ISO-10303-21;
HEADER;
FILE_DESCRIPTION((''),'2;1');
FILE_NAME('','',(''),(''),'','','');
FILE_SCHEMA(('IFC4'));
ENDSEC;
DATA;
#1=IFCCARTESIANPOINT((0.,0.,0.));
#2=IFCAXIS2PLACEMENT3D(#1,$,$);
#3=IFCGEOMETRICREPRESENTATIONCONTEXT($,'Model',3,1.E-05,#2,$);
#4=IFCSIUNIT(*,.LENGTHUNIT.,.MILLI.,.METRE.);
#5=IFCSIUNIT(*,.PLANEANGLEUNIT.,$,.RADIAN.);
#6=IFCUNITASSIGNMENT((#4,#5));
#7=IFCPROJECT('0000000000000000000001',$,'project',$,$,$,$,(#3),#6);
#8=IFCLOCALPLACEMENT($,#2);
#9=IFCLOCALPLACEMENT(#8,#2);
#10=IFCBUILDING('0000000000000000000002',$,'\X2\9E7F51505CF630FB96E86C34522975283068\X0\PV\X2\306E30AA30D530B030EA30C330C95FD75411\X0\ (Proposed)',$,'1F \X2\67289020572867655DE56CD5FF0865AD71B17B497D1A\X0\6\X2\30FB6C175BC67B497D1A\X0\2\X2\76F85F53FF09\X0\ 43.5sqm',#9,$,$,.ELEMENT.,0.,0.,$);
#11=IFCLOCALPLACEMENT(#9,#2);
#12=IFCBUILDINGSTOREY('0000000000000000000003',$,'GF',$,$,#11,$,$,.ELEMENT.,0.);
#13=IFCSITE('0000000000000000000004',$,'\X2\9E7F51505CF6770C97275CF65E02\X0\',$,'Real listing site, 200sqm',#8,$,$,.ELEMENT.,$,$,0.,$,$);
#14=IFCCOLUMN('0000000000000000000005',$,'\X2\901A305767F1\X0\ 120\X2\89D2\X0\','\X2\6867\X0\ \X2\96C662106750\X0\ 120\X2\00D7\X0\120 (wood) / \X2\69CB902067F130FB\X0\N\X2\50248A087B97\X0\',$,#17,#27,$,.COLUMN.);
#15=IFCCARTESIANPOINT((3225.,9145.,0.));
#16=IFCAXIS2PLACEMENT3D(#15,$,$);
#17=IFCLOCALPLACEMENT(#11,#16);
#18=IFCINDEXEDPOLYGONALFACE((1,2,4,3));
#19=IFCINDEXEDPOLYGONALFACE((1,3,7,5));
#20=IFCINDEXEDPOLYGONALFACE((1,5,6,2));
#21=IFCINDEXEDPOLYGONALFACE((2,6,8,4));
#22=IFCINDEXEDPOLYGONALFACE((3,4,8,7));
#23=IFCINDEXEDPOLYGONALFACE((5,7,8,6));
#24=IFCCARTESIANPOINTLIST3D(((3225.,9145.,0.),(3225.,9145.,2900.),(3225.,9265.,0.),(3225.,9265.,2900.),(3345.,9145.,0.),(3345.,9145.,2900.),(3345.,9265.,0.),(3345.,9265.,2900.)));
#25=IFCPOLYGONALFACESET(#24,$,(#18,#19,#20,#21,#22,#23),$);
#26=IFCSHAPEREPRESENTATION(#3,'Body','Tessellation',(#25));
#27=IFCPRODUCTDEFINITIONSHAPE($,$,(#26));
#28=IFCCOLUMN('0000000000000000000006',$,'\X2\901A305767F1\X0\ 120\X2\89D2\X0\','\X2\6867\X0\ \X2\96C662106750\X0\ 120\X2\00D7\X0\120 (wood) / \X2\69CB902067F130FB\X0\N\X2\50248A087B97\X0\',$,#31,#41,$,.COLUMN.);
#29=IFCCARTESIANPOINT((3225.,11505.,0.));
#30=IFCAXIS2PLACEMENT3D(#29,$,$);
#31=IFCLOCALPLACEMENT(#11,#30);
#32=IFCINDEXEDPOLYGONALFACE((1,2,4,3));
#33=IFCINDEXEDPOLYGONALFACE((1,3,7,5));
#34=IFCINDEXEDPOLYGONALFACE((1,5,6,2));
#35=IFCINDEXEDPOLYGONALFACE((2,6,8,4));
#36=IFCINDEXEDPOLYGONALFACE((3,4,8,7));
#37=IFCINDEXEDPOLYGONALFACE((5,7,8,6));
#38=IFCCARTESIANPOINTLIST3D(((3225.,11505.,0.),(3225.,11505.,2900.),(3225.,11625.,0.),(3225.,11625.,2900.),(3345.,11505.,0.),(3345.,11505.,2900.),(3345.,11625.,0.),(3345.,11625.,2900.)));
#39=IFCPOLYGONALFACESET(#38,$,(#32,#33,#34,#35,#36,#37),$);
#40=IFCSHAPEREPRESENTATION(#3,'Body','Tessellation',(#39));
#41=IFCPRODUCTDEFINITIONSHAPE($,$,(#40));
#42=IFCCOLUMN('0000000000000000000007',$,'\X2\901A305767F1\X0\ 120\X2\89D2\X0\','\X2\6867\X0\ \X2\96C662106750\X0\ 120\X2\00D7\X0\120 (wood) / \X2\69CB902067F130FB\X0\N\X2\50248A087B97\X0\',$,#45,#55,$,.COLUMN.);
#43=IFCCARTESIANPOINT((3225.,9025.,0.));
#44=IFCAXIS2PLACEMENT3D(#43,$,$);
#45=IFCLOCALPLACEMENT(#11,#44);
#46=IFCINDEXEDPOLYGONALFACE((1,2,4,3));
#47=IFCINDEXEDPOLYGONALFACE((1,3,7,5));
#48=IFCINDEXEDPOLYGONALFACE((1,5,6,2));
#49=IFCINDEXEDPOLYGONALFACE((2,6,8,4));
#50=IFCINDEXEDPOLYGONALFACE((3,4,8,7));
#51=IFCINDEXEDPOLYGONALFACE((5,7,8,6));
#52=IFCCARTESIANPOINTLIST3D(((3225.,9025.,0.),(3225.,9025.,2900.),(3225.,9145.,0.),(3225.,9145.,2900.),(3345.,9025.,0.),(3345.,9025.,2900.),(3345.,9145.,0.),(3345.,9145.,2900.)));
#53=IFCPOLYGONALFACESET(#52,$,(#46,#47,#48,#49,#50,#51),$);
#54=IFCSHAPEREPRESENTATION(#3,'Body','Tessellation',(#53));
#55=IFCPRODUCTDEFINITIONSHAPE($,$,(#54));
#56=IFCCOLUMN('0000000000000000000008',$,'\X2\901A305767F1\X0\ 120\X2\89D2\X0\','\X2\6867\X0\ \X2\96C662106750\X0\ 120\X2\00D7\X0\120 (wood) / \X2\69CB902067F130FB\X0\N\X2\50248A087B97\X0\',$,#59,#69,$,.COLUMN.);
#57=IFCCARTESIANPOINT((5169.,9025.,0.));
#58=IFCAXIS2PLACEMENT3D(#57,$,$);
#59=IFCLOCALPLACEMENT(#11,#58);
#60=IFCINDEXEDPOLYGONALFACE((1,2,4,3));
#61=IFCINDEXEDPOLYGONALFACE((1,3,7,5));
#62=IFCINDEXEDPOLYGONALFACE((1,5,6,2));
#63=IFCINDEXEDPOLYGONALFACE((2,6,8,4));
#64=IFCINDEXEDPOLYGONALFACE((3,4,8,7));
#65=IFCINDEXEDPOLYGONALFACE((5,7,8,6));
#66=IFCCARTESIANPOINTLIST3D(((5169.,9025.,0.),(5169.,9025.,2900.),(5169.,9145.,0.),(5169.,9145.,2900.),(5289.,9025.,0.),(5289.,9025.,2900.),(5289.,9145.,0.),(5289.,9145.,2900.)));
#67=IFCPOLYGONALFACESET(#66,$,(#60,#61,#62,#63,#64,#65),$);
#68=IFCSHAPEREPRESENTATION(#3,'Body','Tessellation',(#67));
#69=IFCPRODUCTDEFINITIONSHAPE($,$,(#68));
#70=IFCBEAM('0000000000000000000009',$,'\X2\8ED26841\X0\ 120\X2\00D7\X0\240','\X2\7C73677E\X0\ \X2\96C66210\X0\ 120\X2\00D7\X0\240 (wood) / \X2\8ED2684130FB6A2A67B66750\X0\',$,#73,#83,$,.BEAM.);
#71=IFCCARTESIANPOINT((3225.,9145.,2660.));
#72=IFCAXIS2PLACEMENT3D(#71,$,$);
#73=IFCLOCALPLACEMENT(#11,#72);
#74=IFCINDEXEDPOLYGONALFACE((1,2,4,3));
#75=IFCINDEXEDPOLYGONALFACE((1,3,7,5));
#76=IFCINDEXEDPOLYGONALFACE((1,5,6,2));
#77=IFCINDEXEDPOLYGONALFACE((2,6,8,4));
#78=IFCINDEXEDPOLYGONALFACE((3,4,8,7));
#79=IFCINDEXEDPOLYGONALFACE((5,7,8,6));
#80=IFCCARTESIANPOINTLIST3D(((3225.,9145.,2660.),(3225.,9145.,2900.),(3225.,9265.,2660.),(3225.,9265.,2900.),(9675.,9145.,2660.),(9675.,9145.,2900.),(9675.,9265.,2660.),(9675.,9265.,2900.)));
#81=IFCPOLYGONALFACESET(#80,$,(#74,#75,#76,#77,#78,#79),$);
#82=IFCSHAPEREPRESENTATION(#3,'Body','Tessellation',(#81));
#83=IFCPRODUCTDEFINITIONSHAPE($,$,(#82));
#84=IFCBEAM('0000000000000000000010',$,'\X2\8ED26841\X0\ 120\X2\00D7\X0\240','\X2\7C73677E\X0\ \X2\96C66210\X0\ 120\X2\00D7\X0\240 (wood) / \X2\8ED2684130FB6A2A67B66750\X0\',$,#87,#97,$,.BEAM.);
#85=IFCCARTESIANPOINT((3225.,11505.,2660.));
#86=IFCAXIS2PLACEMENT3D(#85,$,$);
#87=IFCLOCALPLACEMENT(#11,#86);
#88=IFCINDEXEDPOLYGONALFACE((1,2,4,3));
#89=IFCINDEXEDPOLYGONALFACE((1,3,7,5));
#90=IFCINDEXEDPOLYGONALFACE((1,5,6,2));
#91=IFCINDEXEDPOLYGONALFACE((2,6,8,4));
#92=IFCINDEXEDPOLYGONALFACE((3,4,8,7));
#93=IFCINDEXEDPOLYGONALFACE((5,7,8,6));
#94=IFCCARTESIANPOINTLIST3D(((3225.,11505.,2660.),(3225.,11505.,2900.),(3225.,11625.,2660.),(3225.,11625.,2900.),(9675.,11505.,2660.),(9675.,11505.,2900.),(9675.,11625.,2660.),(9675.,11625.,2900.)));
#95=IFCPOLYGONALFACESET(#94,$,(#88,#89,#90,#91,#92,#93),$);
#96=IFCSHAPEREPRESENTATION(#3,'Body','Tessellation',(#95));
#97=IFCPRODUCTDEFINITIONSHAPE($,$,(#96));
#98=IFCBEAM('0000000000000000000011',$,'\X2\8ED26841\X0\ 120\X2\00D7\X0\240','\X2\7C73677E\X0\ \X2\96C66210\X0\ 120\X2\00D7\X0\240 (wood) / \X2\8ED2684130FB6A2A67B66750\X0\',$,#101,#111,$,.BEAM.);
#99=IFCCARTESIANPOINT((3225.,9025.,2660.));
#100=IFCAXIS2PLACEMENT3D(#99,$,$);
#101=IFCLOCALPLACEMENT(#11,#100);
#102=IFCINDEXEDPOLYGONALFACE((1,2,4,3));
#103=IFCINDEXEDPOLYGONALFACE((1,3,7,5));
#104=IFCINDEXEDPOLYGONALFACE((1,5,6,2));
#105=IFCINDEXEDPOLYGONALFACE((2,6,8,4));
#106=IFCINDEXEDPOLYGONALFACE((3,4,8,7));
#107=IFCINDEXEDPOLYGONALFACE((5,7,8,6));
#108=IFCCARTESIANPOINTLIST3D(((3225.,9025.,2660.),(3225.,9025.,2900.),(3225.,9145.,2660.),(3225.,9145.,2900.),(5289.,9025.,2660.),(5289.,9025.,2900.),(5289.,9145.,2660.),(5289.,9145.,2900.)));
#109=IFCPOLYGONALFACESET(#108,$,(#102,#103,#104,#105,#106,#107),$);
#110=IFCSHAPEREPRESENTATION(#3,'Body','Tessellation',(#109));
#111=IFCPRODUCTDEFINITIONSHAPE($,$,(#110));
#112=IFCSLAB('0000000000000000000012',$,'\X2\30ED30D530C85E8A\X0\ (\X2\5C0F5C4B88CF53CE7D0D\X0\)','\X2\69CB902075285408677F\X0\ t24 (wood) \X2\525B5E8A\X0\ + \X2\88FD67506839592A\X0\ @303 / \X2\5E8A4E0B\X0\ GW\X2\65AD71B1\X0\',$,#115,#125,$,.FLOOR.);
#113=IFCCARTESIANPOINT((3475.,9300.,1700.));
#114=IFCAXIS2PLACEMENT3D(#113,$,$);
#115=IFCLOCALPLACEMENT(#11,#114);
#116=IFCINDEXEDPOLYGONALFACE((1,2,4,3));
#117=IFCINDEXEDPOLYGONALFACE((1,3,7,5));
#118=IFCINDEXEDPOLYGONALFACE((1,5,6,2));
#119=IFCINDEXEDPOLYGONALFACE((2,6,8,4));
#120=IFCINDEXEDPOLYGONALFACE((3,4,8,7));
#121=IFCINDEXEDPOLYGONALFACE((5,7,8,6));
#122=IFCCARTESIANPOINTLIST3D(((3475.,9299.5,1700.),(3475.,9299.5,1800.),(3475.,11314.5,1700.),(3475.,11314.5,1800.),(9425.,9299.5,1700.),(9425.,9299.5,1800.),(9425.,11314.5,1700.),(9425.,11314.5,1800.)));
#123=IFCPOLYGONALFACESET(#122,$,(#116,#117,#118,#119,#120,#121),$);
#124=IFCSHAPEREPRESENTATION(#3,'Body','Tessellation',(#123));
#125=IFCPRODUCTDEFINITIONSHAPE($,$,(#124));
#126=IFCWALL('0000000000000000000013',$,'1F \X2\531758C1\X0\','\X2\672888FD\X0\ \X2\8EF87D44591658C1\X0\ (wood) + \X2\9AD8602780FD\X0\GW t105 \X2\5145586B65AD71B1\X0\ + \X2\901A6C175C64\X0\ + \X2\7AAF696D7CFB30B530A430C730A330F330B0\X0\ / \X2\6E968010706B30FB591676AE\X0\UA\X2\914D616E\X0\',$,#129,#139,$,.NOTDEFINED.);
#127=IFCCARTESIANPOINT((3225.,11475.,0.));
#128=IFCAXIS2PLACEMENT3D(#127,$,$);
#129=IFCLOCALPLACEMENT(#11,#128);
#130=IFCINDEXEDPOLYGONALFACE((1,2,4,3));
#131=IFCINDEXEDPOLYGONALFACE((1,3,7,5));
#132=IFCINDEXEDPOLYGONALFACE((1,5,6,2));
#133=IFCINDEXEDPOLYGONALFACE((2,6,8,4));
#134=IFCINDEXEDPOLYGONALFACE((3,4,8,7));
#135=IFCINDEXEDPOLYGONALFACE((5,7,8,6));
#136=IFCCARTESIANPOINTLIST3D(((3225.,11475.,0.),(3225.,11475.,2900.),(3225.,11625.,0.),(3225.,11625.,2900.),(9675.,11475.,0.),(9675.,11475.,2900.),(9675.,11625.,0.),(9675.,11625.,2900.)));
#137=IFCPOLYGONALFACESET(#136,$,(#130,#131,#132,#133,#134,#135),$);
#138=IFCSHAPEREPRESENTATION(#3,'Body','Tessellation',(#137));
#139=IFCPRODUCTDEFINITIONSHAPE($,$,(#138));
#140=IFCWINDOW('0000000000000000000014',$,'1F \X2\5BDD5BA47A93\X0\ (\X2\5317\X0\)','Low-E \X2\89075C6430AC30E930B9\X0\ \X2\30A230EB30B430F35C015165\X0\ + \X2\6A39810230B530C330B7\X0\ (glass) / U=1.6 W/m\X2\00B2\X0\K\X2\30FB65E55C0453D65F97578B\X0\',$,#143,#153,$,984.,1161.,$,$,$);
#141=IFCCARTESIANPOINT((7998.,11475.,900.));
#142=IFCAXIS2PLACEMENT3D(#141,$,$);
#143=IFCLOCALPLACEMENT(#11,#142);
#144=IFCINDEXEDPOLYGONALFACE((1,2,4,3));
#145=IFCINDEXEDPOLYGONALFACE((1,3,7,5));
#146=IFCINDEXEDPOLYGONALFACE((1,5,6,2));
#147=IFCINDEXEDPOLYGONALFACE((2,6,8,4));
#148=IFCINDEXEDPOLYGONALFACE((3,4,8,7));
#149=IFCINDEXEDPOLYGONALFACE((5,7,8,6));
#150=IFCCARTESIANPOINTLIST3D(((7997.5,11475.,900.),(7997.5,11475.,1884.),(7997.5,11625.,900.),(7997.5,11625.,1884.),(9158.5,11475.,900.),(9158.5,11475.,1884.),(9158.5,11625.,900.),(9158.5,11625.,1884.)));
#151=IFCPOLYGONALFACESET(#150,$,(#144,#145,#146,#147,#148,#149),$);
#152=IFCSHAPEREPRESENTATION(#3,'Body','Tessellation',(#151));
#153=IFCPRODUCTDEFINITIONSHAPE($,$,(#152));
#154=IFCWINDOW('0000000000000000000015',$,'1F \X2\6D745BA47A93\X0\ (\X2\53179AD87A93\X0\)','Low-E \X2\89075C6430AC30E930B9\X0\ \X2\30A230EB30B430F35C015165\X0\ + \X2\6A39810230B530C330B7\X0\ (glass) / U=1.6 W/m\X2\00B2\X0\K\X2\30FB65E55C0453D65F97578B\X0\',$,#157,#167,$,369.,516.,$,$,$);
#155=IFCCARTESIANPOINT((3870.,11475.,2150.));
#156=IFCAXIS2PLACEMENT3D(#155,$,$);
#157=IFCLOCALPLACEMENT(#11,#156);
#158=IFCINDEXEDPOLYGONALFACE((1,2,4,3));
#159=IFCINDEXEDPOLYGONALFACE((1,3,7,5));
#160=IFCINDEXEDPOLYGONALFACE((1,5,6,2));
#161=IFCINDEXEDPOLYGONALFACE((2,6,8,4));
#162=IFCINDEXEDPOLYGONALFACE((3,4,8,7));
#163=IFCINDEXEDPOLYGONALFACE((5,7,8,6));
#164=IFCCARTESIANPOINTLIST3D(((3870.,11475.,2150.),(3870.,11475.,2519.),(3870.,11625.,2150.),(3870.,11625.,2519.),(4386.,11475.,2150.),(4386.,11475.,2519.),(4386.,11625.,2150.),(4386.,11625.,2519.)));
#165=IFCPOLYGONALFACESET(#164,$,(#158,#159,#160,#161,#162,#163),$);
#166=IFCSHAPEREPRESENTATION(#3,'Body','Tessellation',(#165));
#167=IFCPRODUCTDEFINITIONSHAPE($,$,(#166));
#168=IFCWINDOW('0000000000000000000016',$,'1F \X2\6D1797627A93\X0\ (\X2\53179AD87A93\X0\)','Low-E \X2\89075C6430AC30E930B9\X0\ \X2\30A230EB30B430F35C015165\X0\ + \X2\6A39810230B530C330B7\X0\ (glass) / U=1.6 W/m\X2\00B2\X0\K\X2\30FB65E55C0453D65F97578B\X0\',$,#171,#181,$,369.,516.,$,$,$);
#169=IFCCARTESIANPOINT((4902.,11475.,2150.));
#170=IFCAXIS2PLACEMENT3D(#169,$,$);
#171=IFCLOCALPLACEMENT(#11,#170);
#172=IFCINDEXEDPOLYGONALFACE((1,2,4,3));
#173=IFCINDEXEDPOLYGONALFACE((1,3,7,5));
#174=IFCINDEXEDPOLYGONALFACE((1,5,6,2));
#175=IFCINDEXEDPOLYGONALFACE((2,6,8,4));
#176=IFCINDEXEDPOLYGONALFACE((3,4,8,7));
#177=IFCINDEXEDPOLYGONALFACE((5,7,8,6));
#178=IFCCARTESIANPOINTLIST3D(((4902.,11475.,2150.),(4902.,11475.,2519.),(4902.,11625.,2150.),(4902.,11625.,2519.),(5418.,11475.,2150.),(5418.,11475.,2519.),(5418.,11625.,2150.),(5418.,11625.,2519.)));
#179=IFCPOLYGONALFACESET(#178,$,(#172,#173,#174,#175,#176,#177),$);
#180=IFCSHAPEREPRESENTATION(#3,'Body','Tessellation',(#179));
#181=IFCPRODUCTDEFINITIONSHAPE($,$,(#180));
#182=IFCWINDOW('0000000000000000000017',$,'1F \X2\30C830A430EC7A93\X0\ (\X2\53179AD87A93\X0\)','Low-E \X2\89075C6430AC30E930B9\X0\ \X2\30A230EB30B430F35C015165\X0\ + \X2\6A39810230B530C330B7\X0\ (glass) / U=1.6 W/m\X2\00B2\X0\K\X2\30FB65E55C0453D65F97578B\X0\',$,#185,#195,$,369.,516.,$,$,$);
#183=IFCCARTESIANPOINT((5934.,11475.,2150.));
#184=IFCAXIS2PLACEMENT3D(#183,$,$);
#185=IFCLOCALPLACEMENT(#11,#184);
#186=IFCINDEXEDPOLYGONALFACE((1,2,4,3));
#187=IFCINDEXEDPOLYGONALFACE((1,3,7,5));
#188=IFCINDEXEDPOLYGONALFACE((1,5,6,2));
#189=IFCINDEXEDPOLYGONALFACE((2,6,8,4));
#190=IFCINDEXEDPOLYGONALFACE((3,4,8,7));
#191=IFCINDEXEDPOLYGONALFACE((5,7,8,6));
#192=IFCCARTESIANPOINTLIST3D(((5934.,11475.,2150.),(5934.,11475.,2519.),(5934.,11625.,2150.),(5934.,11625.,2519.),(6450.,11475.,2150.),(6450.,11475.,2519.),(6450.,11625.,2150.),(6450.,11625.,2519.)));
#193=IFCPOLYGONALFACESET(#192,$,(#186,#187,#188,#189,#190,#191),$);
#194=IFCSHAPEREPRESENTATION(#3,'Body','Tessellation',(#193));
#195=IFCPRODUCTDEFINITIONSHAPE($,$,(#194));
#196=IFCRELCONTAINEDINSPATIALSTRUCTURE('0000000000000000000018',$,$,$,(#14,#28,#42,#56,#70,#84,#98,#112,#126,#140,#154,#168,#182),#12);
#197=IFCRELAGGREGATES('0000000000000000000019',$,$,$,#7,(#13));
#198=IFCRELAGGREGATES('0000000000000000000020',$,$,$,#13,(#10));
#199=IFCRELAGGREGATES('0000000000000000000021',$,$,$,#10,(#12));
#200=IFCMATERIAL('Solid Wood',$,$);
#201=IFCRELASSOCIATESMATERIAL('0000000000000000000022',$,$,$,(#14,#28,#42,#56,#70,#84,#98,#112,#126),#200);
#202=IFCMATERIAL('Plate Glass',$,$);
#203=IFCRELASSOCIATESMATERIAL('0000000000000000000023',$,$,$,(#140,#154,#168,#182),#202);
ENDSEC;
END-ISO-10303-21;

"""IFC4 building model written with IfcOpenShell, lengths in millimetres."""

from ifc_helpers import new_model, si_unit, frame, frame_2d, origin, place, context, project, spatial, rectangle, extrude, material, element, fill, save


model = new_model("IFC4")

# Units and contexts
model_context = context("Model", 3, precision=1e-05, world=origin())
ifc_project = project(units=[si_unit("LENGTHUNIT", "METRE", prefix="MILLI"), si_unit("PLANEANGLEUNIT", "RADIAN")], contexts=[model_context])

# Site, building, storey
site_placement = place(None, origin())
site = spatial("IfcSite", under=ifc_project, at=site_placement, Name="鹿児島県霧島市", ObjectType="Real listing site, 200sqm", CompositionType="ELEMENT", RefElevation=0.0)
building_placement = place(site_placement, origin())
building = spatial("IfcBuilding", under=site, at=building_placement, Name="鹿児島・雨水利用とPVのオフグリッド志向 (Proposed)", ObjectType="1F 木造在来工法（断熱等級6・気密等級2相当） 43.5sqm", CompositionType="ELEMENT", ElevationOfRefHeight=0.0, ElevationOfTerrain=0.0)
storey_placement = place(building_placement, origin())
storey = spatial("IfcBuildingStorey", under=building, at=storey_placement, Name="GF", CompositionType="ELEMENT", Elevation=0.0)

# Columns
ifc_material_1 = material(Name="Solid Wood")
column_1_placement = place(storey_placement, frame((3225.0, 9145.0, 0.0)))
element("IfcColumn", 1, at=column_1_placement, inside=storey, material=ifc_material_1, Name="通し柱 120角", Description="桧 集成材 120×120 (wood) / 構造柱・N値計算", PredefinedType="COLUMN", context=model_context, shape_type="SweptSolid", body=[
    extrude(rectangle(XDim=120.0, YDim=120.0, at=frame_2d((60.0, 60.0))), frame((3225.0, 9145.0, 0.0)), (0.0, 0.0, 1.0), 2900.0),
])
column_2_placement = place(storey_placement, frame((3225.0, 11505.0, 0.0)))
element("IfcColumn", 2, at=column_2_placement, inside=storey, material=ifc_material_1, Name="通し柱 120角", Description="桧 集成材 120×120 (wood) / 構造柱・N値計算", PredefinedType="COLUMN", context=model_context, shape_type="SweptSolid", body=[
    extrude(rectangle(XDim=120.0, YDim=120.0, at=frame_2d((60.0, 60.0))), frame((3225.0, 11505.0, 0.0)), (0.0, 0.0, 1.0), 2900.0),
])
column_3_placement = place(storey_placement, frame((3225.0, 9025.0, 0.0)))
element("IfcColumn", 3, at=column_3_placement, inside=storey, material=ifc_material_1, Name="通し柱 120角", Description="桧 集成材 120×120 (wood) / 構造柱・N値計算", PredefinedType="COLUMN", context=model_context, shape_type="SweptSolid", body=[
    extrude(rectangle(XDim=120.0, YDim=120.0, at=frame_2d((60.0, 60.0))), frame((3225.0, 9025.0, 0.0)), (0.0, 0.0, 1.0), 2900.0),
])
column_4_placement = place(storey_placement, frame((5169.0, 9025.0, 0.0)))
element("IfcColumn", 4, at=column_4_placement, inside=storey, material=ifc_material_1, Name="通し柱 120角", Description="桧 集成材 120×120 (wood) / 構造柱・N値計算", PredefinedType="COLUMN", context=model_context, shape_type="SweptSolid", body=[
    extrude(rectangle(XDim=120.0, YDim=120.0, at=frame_2d((60.0, 60.0))), frame((5169.0, 9025.0, 0.0)), (0.0, 0.0, 1.0), 2900.0),
])

# Beams
beam_1_placement = place(storey_placement, frame((3225.0, 9145.0, 2660.0)))
element("IfcBeam", 5, at=beam_1_placement, inside=storey, material=ifc_material_1, Name="軒桁 120×240", Description="米松 集成 120×240 (wood) / 軒桁・横架材", PredefinedType="BEAM", context=model_context, shape_type="SweptSolid", body=[
    extrude(rectangle(XDim=6450.0, YDim=120.0, at=frame_2d((3225.0, 60.0))), frame((3225.0, 9145.0, 2660.0)), (0.0, 0.0, 1.0), 240.0),
])
beam_2_placement = place(storey_placement, frame((3225.0, 11505.0, 2660.0)))
element("IfcBeam", 6, at=beam_2_placement, inside=storey, material=ifc_material_1, Name="軒桁 120×240", Description="米松 集成 120×240 (wood) / 軒桁・横架材", PredefinedType="BEAM", context=model_context, shape_type="SweptSolid", body=[
    extrude(rectangle(XDim=6450.0, YDim=120.0, at=frame_2d((3225.0, 60.0))), frame((3225.0, 11505.0, 2660.0)), (0.0, 0.0, 1.0), 240.0),
])
beam_3_placement = place(storey_placement, frame((3225.0, 9025.0, 2660.0)))
element("IfcBeam", 7, at=beam_3_placement, inside=storey, material=ifc_material_1, Name="軒桁 120×240", Description="米松 集成 120×240 (wood) / 軒桁・横架材", PredefinedType="BEAM", context=model_context, shape_type="SweptSolid", body=[
    extrude(rectangle(XDim=2064.0, YDim=120.0, at=frame_2d((1032.0, 60.0))), frame((3225.0, 9025.0, 2660.0)), (0.0, 0.0, 1.0), 240.0),
])

# Slab
slab_1_placement = place(storey_placement, frame((3475.0, 9300.0, 1700.0)))
element("IfcSlab", 8, at=slab_1_placement, inside=storey, material=ifc_material_1, Name="ロフト床 (小屋裏収納)", Description="構造用合板 t24 (wood) 剛床 + 製材根太 @303 / 床下 GW断熱", PredefinedType="FLOOR", context=model_context, shape_type="SweptSolid", body=[
    extrude(rectangle(XDim=5950.0, YDim=2015.0, at=frame_2d((2975.0, 1007.0))), frame((3475.0, 9300.0, 1700.0)), (0.0, 0.0, 1.0), 100.0),
])

# Wall, openings, windows
wall_1_placement = place(storey_placement, frame((3225.0, 11475.0, 0.0)))
wall_1 = element("IfcWall", 9, at=wall_1_placement, inside=storey, material=ifc_material_1, Name="1F 北壁", Description="木製 軸組外壁 (wood) + 高性能GW t105 充填断熱 + 通気層 + 窯業系サイディング / 準耐火・外皮UA配慮", PredefinedType="NOTDEFINED", context=model_context, shape_type="SweptSolid", body=[
    extrude(rectangle(XDim=6450.0, YDim=150.0, at=frame_2d((3225.0, 75.0))), frame((3225.0, 11475.0, 0.0)), (0.0, 0.0, 1.0), 2900.0),
])
opening_1_placement = place(storey_placement, frame((7998.0, 11475.0, 900.0)))
opening_1 = element("IfcOpeningElement", 10, at=opening_1_placement, cuts=wall_1, PredefinedType="NOTDEFINED", context=model_context, shape_type="SweptSolid", body=[
    extrude(rectangle(XDim=1161.0, YDim=150.0, at=frame_2d((580.0, 75.0))), frame((7998.0, 11475.0, 900.0)), (0.0, 0.0, 1.0), 984.0),
])
opening_2_placement = place(storey_placement, frame((3870.0, 11475.0, 2150.0)))
opening_2 = element("IfcOpeningElement", 11, at=opening_2_placement, cuts=wall_1, PredefinedType="NOTDEFINED", context=model_context, shape_type="SweptSolid", body=[
    extrude(rectangle(XDim=516.0, YDim=150.0, at=frame_2d((258.0, 75.0))), frame((3870.0, 11475.0, 2150.0)), (0.0, 0.0, 1.0), 369.0),
])
opening_3_placement = place(storey_placement, frame((4902.0, 11475.0, 2150.0)))
opening_3 = element("IfcOpeningElement", 12, at=opening_3_placement, cuts=wall_1, PredefinedType="NOTDEFINED", context=model_context, shape_type="SweptSolid", body=[
    extrude(rectangle(XDim=516.0, YDim=150.0, at=frame_2d((258.0, 75.0))), frame((4902.0, 11475.0, 2150.0)), (0.0, 0.0, 1.0), 369.0),
])
opening_4_placement = place(storey_placement, frame((5934.0, 11475.0, 2150.0)))
opening_4 = element("IfcOpeningElement", 13, at=opening_4_placement, cuts=wall_1, PredefinedType="NOTDEFINED", context=model_context, shape_type="SweptSolid", body=[
    extrude(rectangle(XDim=516.0, YDim=150.0, at=frame_2d((258.0, 75.0))), frame((5934.0, 11475.0, 2150.0)), (0.0, 0.0, 1.0), 369.0),
])
ifc_material_2 = material(Name="Plate Glass")
window_1_placement = place(storey_placement, frame((7998.0, 11475.0, 900.0)))
window_1 = element("IfcWindow", 14, at=window_1_placement, inside=storey, material=ifc_material_2, Name="1F 寝室窓 (北)", Description="Low-E 複層ガラス アルゴン封入 + 樹脂サッシ (glass) / U=1.6 W/m²K・日射取得型", OverallHeight=984.0, OverallWidth=1161.0, context=model_context, shape_type="SweptSolid", body=[
    extrude(rectangle(XDim=1161.0, YDim=150.0, at=frame_2d((580.0, 75.0))), frame((7998.0, 11475.0, 900.0)), (0.0, 0.0, 1.0), 984.0),
])
fill(opening_1, window_1)
window_2_placement = place(storey_placement, frame((3870.0, 11475.0, 2150.0)))
window_2 = element("IfcWindow", 15, at=window_2_placement, inside=storey, material=ifc_material_2, Name="1F 浴室窓 (北高窓)", Description="Low-E 複層ガラス アルゴン封入 + 樹脂サッシ (glass) / U=1.6 W/m²K・日射取得型", OverallHeight=369.0, OverallWidth=516.0, context=model_context, shape_type="SweptSolid", body=[
    extrude(rectangle(XDim=516.0, YDim=150.0, at=frame_2d((258.0, 75.0))), frame((3870.0, 11475.0, 2150.0)), (0.0, 0.0, 1.0), 369.0),
])
fill(opening_2, window_2)
window_3_placement = place(storey_placement, frame((4902.0, 11475.0, 2150.0)))
window_3 = element("IfcWindow", 16, at=window_3_placement, inside=storey, material=ifc_material_2, Name="1F 洗面窓 (北高窓)", Description="Low-E 複層ガラス アルゴン封入 + 樹脂サッシ (glass) / U=1.6 W/m²K・日射取得型", OverallHeight=369.0, OverallWidth=516.0, context=model_context, shape_type="SweptSolid", body=[
    extrude(rectangle(XDim=516.0, YDim=150.0, at=frame_2d((258.0, 75.0))), frame((4902.0, 11475.0, 2150.0)), (0.0, 0.0, 1.0), 369.0),
])
fill(opening_3, window_3)
window_4_placement = place(storey_placement, frame((5934.0, 11475.0, 2150.0)))
window_4 = element("IfcWindow", 17, at=window_4_placement, inside=storey, material=ifc_material_2, Name="1F トイレ窓 (北高窓)", Description="Low-E 複層ガラス アルゴン封入 + 樹脂サッシ (glass) / U=1.6 W/m²K・日射取得型", OverallHeight=369.0, OverallWidth=516.0, context=model_context, shape_type="SweptSolid", body=[
    extrude(rectangle(XDim=516.0, YDim=150.0, at=frame_2d((258.0, 75.0))), frame((5934.0, 11475.0, 2150.0)), (0.0, 0.0, 1.0), 369.0),
])
fill(opening_4, window_4)

save(model, "model.ifc")
